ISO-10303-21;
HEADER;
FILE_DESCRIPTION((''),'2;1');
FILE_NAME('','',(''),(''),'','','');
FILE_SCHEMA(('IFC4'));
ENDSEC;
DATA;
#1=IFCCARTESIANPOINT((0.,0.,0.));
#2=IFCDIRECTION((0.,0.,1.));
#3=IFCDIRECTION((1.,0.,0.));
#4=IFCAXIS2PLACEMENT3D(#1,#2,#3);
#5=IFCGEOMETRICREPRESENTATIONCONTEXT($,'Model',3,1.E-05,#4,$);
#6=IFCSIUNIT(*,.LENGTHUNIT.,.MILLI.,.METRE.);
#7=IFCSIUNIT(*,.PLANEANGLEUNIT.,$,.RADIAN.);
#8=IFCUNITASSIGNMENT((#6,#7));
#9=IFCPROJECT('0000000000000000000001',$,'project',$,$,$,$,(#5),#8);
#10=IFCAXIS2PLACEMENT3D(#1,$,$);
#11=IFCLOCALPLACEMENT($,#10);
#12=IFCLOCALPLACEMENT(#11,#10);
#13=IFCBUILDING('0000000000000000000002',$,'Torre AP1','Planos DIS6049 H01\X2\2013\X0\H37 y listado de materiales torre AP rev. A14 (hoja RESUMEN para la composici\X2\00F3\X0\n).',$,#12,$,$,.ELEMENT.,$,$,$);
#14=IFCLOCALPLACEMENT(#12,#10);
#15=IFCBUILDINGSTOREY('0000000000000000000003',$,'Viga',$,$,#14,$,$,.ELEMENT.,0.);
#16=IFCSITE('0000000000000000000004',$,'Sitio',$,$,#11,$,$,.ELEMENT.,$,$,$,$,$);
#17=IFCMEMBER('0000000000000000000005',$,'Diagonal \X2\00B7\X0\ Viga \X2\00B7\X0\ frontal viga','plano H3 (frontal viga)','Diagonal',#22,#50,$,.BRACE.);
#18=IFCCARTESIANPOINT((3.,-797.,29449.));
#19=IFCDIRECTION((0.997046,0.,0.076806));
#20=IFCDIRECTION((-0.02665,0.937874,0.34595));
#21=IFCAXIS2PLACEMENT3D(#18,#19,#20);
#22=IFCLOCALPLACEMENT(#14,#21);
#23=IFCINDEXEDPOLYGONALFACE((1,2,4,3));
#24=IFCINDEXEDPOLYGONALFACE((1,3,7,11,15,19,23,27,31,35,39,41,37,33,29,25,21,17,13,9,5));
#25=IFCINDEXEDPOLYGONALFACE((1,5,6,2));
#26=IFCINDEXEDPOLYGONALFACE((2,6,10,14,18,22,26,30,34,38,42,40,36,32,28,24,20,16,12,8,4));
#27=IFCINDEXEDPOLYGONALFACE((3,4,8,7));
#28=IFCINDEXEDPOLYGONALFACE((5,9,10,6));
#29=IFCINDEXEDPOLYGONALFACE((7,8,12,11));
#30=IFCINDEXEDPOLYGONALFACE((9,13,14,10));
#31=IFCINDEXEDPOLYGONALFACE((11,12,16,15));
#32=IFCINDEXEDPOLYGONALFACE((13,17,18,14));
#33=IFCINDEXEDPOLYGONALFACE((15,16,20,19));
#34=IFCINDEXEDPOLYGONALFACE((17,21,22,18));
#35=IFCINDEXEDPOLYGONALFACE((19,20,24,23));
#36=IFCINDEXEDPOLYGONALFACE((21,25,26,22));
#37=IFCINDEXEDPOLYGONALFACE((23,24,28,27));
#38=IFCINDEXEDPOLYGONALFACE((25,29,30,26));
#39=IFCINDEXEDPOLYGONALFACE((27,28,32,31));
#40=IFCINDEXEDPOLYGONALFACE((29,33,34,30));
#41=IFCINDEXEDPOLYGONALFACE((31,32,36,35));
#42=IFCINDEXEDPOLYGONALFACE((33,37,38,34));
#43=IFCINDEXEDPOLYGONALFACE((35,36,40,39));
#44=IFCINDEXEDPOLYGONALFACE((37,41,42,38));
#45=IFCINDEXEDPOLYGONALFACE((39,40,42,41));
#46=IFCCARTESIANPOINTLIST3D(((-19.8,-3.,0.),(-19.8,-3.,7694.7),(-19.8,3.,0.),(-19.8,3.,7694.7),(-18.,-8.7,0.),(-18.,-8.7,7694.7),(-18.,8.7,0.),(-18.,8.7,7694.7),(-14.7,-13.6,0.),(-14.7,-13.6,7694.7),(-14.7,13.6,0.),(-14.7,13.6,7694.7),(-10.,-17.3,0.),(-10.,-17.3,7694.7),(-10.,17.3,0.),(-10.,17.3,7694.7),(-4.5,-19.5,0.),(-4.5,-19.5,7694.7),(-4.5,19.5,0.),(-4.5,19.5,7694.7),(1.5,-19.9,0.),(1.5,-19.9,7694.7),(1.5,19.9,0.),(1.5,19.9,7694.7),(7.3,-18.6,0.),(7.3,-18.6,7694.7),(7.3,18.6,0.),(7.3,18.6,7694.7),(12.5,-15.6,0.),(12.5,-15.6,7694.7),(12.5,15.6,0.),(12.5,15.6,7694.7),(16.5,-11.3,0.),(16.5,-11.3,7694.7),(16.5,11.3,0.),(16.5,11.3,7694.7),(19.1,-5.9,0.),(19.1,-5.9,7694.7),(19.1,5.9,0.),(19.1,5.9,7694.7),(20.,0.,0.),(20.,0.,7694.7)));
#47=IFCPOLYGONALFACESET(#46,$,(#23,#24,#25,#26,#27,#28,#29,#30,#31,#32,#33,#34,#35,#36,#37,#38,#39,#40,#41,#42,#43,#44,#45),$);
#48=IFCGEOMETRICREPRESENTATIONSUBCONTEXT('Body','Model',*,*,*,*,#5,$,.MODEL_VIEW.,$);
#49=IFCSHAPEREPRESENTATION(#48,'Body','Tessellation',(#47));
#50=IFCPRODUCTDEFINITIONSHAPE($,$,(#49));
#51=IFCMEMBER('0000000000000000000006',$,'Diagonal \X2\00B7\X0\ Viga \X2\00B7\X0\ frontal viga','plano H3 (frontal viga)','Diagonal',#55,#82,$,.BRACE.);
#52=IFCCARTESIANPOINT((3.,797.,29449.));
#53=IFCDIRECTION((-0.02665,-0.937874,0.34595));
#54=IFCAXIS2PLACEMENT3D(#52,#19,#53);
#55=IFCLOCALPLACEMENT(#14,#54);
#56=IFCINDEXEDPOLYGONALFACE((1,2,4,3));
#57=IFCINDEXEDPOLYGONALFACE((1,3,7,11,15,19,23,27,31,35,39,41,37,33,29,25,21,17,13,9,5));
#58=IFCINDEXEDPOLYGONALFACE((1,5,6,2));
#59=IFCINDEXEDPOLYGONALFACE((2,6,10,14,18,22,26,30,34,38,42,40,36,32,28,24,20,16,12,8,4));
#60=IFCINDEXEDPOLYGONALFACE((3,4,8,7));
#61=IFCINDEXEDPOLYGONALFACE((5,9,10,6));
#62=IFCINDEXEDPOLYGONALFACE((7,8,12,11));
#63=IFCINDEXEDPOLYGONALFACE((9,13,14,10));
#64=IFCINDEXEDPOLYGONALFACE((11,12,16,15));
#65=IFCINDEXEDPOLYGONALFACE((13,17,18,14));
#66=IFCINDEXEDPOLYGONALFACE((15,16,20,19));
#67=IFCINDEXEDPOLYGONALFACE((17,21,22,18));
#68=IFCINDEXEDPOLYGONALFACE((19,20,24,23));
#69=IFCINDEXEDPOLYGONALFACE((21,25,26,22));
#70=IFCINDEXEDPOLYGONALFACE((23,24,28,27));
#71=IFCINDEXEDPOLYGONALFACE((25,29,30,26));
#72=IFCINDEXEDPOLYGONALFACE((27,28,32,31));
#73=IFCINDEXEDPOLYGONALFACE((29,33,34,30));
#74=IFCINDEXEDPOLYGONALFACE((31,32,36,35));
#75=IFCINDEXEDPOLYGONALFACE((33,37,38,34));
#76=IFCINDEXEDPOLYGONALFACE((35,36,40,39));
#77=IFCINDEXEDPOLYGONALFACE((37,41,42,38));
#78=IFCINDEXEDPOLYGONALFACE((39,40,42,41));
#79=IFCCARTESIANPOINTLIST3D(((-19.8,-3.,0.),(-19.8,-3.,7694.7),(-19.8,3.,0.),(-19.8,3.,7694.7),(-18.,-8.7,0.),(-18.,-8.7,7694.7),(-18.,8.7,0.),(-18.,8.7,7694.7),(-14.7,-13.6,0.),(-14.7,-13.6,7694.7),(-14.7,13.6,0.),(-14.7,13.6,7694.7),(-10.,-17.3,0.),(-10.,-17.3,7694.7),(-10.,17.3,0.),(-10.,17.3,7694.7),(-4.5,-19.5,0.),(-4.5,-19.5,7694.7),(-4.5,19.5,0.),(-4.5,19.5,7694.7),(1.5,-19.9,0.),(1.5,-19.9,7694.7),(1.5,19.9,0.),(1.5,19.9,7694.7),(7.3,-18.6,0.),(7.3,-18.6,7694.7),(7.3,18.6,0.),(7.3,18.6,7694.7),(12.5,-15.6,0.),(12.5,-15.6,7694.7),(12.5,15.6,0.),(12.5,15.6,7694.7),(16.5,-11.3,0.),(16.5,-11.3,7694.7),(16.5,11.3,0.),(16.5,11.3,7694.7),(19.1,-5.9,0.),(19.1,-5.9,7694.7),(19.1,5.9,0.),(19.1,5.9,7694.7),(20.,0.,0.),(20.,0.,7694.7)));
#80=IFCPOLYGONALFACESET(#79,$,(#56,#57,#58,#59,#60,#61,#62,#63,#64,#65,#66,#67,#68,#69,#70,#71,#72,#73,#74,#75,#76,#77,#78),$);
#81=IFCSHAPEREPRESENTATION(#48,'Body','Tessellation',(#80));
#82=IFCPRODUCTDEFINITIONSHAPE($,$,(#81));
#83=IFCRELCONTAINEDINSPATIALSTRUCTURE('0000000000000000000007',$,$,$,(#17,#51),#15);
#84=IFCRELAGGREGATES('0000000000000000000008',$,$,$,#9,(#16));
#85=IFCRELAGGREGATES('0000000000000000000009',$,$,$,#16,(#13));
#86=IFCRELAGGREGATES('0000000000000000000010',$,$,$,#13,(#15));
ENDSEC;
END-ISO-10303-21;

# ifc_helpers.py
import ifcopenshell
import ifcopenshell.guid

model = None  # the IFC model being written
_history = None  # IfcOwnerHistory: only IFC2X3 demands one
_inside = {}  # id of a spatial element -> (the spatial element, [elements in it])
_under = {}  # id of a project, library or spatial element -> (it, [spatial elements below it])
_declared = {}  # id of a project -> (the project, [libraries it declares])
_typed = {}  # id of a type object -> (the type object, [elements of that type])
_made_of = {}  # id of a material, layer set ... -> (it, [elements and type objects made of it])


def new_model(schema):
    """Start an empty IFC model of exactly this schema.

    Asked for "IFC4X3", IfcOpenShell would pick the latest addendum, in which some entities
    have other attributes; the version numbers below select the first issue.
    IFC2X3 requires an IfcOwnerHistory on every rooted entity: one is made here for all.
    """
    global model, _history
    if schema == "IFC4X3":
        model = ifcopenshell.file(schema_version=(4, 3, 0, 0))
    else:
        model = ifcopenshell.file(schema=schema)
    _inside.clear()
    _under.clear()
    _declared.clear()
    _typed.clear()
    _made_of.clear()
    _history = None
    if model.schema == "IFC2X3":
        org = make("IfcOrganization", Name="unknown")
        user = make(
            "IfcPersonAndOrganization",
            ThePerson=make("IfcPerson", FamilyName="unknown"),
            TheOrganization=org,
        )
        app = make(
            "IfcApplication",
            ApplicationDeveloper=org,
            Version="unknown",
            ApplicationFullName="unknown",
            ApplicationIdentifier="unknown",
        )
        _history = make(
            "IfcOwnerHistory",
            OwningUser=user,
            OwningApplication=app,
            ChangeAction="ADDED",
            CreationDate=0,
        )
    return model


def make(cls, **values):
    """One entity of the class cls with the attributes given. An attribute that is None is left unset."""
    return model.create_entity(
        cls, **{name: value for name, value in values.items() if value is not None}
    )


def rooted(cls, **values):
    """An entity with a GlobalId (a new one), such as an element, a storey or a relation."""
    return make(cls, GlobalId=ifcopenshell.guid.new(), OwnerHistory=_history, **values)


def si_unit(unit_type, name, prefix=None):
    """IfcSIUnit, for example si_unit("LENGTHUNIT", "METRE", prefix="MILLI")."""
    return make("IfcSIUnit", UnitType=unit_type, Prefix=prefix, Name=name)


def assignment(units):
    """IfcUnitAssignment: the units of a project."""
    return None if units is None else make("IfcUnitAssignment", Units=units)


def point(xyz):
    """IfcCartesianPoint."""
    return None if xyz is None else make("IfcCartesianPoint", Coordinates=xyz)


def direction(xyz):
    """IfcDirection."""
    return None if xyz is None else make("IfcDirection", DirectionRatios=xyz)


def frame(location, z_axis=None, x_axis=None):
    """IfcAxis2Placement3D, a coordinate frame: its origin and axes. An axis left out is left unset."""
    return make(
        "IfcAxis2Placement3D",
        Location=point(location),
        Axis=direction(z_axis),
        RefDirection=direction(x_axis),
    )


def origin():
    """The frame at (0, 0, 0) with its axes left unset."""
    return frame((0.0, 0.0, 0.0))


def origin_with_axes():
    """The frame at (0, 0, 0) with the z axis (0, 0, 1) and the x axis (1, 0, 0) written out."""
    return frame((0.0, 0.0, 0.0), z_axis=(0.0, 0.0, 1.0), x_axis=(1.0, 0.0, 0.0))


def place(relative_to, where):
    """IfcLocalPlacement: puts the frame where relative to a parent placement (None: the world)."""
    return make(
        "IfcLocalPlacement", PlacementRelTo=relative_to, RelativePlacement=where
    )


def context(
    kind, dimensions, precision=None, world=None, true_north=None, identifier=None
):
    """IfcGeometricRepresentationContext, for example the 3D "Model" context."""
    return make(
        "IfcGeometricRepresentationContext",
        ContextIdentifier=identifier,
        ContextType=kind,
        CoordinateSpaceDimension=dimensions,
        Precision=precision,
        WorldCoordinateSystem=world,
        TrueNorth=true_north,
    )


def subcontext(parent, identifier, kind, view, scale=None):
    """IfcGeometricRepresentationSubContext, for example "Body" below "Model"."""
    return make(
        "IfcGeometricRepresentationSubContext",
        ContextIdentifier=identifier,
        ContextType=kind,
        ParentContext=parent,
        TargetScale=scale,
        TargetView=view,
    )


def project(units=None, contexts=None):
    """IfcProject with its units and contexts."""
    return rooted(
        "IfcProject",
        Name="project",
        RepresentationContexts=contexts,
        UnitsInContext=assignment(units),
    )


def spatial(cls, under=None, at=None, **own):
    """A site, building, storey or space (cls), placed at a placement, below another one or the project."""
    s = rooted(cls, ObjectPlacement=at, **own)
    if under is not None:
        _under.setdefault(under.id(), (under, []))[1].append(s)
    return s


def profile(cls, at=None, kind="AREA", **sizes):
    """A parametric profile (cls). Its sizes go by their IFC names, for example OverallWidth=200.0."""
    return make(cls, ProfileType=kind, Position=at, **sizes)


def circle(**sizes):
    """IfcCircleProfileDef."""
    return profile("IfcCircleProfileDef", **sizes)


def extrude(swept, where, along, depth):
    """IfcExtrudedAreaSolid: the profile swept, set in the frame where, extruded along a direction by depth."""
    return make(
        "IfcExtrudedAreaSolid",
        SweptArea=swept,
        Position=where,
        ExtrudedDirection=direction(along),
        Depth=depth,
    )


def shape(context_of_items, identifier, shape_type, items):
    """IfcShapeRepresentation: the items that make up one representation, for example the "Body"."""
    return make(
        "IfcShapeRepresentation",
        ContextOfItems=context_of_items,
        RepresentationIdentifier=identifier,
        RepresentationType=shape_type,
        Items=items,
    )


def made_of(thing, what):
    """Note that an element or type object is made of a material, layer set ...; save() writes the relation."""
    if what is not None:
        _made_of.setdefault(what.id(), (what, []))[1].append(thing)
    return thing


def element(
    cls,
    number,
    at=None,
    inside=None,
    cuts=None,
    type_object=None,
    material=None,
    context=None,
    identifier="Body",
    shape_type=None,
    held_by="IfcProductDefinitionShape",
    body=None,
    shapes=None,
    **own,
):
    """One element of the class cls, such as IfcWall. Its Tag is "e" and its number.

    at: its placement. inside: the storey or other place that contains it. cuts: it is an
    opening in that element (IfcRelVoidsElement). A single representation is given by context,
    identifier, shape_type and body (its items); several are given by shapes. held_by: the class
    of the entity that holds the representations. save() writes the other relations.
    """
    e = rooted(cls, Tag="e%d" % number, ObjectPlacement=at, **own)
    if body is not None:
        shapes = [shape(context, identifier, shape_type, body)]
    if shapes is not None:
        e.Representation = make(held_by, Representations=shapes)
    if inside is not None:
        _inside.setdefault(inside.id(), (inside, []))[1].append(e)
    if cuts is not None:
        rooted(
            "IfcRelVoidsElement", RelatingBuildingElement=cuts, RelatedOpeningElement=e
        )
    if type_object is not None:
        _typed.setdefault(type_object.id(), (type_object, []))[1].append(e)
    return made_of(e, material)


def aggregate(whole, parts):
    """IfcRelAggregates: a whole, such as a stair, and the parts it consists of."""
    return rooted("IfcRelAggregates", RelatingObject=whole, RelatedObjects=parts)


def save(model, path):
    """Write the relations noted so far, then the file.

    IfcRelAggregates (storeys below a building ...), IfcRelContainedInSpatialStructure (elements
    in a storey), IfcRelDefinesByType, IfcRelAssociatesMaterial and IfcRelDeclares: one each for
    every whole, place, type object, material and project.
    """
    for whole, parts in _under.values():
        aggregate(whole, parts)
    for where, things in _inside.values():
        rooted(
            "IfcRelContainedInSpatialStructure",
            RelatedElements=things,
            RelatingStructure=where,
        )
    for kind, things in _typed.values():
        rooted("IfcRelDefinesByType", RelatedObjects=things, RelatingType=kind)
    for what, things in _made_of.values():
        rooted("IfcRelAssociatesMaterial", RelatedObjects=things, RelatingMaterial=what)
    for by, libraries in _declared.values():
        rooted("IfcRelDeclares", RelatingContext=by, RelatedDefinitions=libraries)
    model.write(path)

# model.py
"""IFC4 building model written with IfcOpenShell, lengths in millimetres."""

from ifc_helpers import new_model, si_unit, frame, origin, origin_with_axes, place, context, subcontext, project, spatial, circle, extrude, element, save


model = new_model("IFC4")

# Units and contexts
model_context = context("Model", 3, precision=1e-05, world=origin_with_axes())
body_context = subcontext(model_context, "Body", "Model", "MODEL_VIEW")
ifc_project = project(units=[si_unit("LENGTHUNIT", "METRE", prefix="MILLI"), si_unit("PLANEANGLEUNIT", "RADIAN")], contexts=[model_context])

# Site, building, storey
site_placement = place(None, origin())
site = spatial("IfcSite", under=ifc_project, at=site_placement, Name="Sitio", CompositionType="ELEMENT")
building_placement = place(site_placement, origin())
building = spatial("IfcBuilding", under=site, at=building_placement, Name="Torre AP1", Description="Planos DIS6049 H01–H37 y listado de materiales torre AP rev. A14 (hoja RESUMEN para la composición).", CompositionType="ELEMENT")
storey_placement = place(building_placement, origin())
storey = spatial("IfcBuildingStorey", under=building, at=storey_placement, Name="Viga", CompositionType="ELEMENT", Elevation=0.0)

# Members
for number, where, z_axis, x_axis, name in (
    (1, (3.0, -797.0, 29449.0), (0.997046, 0.0, 0.076806), (-0.02665, 0.937874, 0.34595), "Diagonal · Viga · frontal viga"),
    (2, (3.0, 797.0, 29449.0), (0.997046, 0.0, 0.076806), (-0.02665, -0.937874, 0.34595), "Diagonal · Viga · frontal viga"),
):
    element("IfcMember", number, at=place(storey_placement, frame(where, z_axis=z_axis, x_axis=x_axis)), inside=storey, Name=name, Description="plano H3 (frontal viga)", ObjectType="Diagonal", PredefinedType="BRACE", context=body_context, shape_type="SweptSolid", body=[
        extrude(circle(Radius=20.0), None, (0.0, 0.0, 1.0), 7694.7),
    ])

save(model, "model.ifc")
